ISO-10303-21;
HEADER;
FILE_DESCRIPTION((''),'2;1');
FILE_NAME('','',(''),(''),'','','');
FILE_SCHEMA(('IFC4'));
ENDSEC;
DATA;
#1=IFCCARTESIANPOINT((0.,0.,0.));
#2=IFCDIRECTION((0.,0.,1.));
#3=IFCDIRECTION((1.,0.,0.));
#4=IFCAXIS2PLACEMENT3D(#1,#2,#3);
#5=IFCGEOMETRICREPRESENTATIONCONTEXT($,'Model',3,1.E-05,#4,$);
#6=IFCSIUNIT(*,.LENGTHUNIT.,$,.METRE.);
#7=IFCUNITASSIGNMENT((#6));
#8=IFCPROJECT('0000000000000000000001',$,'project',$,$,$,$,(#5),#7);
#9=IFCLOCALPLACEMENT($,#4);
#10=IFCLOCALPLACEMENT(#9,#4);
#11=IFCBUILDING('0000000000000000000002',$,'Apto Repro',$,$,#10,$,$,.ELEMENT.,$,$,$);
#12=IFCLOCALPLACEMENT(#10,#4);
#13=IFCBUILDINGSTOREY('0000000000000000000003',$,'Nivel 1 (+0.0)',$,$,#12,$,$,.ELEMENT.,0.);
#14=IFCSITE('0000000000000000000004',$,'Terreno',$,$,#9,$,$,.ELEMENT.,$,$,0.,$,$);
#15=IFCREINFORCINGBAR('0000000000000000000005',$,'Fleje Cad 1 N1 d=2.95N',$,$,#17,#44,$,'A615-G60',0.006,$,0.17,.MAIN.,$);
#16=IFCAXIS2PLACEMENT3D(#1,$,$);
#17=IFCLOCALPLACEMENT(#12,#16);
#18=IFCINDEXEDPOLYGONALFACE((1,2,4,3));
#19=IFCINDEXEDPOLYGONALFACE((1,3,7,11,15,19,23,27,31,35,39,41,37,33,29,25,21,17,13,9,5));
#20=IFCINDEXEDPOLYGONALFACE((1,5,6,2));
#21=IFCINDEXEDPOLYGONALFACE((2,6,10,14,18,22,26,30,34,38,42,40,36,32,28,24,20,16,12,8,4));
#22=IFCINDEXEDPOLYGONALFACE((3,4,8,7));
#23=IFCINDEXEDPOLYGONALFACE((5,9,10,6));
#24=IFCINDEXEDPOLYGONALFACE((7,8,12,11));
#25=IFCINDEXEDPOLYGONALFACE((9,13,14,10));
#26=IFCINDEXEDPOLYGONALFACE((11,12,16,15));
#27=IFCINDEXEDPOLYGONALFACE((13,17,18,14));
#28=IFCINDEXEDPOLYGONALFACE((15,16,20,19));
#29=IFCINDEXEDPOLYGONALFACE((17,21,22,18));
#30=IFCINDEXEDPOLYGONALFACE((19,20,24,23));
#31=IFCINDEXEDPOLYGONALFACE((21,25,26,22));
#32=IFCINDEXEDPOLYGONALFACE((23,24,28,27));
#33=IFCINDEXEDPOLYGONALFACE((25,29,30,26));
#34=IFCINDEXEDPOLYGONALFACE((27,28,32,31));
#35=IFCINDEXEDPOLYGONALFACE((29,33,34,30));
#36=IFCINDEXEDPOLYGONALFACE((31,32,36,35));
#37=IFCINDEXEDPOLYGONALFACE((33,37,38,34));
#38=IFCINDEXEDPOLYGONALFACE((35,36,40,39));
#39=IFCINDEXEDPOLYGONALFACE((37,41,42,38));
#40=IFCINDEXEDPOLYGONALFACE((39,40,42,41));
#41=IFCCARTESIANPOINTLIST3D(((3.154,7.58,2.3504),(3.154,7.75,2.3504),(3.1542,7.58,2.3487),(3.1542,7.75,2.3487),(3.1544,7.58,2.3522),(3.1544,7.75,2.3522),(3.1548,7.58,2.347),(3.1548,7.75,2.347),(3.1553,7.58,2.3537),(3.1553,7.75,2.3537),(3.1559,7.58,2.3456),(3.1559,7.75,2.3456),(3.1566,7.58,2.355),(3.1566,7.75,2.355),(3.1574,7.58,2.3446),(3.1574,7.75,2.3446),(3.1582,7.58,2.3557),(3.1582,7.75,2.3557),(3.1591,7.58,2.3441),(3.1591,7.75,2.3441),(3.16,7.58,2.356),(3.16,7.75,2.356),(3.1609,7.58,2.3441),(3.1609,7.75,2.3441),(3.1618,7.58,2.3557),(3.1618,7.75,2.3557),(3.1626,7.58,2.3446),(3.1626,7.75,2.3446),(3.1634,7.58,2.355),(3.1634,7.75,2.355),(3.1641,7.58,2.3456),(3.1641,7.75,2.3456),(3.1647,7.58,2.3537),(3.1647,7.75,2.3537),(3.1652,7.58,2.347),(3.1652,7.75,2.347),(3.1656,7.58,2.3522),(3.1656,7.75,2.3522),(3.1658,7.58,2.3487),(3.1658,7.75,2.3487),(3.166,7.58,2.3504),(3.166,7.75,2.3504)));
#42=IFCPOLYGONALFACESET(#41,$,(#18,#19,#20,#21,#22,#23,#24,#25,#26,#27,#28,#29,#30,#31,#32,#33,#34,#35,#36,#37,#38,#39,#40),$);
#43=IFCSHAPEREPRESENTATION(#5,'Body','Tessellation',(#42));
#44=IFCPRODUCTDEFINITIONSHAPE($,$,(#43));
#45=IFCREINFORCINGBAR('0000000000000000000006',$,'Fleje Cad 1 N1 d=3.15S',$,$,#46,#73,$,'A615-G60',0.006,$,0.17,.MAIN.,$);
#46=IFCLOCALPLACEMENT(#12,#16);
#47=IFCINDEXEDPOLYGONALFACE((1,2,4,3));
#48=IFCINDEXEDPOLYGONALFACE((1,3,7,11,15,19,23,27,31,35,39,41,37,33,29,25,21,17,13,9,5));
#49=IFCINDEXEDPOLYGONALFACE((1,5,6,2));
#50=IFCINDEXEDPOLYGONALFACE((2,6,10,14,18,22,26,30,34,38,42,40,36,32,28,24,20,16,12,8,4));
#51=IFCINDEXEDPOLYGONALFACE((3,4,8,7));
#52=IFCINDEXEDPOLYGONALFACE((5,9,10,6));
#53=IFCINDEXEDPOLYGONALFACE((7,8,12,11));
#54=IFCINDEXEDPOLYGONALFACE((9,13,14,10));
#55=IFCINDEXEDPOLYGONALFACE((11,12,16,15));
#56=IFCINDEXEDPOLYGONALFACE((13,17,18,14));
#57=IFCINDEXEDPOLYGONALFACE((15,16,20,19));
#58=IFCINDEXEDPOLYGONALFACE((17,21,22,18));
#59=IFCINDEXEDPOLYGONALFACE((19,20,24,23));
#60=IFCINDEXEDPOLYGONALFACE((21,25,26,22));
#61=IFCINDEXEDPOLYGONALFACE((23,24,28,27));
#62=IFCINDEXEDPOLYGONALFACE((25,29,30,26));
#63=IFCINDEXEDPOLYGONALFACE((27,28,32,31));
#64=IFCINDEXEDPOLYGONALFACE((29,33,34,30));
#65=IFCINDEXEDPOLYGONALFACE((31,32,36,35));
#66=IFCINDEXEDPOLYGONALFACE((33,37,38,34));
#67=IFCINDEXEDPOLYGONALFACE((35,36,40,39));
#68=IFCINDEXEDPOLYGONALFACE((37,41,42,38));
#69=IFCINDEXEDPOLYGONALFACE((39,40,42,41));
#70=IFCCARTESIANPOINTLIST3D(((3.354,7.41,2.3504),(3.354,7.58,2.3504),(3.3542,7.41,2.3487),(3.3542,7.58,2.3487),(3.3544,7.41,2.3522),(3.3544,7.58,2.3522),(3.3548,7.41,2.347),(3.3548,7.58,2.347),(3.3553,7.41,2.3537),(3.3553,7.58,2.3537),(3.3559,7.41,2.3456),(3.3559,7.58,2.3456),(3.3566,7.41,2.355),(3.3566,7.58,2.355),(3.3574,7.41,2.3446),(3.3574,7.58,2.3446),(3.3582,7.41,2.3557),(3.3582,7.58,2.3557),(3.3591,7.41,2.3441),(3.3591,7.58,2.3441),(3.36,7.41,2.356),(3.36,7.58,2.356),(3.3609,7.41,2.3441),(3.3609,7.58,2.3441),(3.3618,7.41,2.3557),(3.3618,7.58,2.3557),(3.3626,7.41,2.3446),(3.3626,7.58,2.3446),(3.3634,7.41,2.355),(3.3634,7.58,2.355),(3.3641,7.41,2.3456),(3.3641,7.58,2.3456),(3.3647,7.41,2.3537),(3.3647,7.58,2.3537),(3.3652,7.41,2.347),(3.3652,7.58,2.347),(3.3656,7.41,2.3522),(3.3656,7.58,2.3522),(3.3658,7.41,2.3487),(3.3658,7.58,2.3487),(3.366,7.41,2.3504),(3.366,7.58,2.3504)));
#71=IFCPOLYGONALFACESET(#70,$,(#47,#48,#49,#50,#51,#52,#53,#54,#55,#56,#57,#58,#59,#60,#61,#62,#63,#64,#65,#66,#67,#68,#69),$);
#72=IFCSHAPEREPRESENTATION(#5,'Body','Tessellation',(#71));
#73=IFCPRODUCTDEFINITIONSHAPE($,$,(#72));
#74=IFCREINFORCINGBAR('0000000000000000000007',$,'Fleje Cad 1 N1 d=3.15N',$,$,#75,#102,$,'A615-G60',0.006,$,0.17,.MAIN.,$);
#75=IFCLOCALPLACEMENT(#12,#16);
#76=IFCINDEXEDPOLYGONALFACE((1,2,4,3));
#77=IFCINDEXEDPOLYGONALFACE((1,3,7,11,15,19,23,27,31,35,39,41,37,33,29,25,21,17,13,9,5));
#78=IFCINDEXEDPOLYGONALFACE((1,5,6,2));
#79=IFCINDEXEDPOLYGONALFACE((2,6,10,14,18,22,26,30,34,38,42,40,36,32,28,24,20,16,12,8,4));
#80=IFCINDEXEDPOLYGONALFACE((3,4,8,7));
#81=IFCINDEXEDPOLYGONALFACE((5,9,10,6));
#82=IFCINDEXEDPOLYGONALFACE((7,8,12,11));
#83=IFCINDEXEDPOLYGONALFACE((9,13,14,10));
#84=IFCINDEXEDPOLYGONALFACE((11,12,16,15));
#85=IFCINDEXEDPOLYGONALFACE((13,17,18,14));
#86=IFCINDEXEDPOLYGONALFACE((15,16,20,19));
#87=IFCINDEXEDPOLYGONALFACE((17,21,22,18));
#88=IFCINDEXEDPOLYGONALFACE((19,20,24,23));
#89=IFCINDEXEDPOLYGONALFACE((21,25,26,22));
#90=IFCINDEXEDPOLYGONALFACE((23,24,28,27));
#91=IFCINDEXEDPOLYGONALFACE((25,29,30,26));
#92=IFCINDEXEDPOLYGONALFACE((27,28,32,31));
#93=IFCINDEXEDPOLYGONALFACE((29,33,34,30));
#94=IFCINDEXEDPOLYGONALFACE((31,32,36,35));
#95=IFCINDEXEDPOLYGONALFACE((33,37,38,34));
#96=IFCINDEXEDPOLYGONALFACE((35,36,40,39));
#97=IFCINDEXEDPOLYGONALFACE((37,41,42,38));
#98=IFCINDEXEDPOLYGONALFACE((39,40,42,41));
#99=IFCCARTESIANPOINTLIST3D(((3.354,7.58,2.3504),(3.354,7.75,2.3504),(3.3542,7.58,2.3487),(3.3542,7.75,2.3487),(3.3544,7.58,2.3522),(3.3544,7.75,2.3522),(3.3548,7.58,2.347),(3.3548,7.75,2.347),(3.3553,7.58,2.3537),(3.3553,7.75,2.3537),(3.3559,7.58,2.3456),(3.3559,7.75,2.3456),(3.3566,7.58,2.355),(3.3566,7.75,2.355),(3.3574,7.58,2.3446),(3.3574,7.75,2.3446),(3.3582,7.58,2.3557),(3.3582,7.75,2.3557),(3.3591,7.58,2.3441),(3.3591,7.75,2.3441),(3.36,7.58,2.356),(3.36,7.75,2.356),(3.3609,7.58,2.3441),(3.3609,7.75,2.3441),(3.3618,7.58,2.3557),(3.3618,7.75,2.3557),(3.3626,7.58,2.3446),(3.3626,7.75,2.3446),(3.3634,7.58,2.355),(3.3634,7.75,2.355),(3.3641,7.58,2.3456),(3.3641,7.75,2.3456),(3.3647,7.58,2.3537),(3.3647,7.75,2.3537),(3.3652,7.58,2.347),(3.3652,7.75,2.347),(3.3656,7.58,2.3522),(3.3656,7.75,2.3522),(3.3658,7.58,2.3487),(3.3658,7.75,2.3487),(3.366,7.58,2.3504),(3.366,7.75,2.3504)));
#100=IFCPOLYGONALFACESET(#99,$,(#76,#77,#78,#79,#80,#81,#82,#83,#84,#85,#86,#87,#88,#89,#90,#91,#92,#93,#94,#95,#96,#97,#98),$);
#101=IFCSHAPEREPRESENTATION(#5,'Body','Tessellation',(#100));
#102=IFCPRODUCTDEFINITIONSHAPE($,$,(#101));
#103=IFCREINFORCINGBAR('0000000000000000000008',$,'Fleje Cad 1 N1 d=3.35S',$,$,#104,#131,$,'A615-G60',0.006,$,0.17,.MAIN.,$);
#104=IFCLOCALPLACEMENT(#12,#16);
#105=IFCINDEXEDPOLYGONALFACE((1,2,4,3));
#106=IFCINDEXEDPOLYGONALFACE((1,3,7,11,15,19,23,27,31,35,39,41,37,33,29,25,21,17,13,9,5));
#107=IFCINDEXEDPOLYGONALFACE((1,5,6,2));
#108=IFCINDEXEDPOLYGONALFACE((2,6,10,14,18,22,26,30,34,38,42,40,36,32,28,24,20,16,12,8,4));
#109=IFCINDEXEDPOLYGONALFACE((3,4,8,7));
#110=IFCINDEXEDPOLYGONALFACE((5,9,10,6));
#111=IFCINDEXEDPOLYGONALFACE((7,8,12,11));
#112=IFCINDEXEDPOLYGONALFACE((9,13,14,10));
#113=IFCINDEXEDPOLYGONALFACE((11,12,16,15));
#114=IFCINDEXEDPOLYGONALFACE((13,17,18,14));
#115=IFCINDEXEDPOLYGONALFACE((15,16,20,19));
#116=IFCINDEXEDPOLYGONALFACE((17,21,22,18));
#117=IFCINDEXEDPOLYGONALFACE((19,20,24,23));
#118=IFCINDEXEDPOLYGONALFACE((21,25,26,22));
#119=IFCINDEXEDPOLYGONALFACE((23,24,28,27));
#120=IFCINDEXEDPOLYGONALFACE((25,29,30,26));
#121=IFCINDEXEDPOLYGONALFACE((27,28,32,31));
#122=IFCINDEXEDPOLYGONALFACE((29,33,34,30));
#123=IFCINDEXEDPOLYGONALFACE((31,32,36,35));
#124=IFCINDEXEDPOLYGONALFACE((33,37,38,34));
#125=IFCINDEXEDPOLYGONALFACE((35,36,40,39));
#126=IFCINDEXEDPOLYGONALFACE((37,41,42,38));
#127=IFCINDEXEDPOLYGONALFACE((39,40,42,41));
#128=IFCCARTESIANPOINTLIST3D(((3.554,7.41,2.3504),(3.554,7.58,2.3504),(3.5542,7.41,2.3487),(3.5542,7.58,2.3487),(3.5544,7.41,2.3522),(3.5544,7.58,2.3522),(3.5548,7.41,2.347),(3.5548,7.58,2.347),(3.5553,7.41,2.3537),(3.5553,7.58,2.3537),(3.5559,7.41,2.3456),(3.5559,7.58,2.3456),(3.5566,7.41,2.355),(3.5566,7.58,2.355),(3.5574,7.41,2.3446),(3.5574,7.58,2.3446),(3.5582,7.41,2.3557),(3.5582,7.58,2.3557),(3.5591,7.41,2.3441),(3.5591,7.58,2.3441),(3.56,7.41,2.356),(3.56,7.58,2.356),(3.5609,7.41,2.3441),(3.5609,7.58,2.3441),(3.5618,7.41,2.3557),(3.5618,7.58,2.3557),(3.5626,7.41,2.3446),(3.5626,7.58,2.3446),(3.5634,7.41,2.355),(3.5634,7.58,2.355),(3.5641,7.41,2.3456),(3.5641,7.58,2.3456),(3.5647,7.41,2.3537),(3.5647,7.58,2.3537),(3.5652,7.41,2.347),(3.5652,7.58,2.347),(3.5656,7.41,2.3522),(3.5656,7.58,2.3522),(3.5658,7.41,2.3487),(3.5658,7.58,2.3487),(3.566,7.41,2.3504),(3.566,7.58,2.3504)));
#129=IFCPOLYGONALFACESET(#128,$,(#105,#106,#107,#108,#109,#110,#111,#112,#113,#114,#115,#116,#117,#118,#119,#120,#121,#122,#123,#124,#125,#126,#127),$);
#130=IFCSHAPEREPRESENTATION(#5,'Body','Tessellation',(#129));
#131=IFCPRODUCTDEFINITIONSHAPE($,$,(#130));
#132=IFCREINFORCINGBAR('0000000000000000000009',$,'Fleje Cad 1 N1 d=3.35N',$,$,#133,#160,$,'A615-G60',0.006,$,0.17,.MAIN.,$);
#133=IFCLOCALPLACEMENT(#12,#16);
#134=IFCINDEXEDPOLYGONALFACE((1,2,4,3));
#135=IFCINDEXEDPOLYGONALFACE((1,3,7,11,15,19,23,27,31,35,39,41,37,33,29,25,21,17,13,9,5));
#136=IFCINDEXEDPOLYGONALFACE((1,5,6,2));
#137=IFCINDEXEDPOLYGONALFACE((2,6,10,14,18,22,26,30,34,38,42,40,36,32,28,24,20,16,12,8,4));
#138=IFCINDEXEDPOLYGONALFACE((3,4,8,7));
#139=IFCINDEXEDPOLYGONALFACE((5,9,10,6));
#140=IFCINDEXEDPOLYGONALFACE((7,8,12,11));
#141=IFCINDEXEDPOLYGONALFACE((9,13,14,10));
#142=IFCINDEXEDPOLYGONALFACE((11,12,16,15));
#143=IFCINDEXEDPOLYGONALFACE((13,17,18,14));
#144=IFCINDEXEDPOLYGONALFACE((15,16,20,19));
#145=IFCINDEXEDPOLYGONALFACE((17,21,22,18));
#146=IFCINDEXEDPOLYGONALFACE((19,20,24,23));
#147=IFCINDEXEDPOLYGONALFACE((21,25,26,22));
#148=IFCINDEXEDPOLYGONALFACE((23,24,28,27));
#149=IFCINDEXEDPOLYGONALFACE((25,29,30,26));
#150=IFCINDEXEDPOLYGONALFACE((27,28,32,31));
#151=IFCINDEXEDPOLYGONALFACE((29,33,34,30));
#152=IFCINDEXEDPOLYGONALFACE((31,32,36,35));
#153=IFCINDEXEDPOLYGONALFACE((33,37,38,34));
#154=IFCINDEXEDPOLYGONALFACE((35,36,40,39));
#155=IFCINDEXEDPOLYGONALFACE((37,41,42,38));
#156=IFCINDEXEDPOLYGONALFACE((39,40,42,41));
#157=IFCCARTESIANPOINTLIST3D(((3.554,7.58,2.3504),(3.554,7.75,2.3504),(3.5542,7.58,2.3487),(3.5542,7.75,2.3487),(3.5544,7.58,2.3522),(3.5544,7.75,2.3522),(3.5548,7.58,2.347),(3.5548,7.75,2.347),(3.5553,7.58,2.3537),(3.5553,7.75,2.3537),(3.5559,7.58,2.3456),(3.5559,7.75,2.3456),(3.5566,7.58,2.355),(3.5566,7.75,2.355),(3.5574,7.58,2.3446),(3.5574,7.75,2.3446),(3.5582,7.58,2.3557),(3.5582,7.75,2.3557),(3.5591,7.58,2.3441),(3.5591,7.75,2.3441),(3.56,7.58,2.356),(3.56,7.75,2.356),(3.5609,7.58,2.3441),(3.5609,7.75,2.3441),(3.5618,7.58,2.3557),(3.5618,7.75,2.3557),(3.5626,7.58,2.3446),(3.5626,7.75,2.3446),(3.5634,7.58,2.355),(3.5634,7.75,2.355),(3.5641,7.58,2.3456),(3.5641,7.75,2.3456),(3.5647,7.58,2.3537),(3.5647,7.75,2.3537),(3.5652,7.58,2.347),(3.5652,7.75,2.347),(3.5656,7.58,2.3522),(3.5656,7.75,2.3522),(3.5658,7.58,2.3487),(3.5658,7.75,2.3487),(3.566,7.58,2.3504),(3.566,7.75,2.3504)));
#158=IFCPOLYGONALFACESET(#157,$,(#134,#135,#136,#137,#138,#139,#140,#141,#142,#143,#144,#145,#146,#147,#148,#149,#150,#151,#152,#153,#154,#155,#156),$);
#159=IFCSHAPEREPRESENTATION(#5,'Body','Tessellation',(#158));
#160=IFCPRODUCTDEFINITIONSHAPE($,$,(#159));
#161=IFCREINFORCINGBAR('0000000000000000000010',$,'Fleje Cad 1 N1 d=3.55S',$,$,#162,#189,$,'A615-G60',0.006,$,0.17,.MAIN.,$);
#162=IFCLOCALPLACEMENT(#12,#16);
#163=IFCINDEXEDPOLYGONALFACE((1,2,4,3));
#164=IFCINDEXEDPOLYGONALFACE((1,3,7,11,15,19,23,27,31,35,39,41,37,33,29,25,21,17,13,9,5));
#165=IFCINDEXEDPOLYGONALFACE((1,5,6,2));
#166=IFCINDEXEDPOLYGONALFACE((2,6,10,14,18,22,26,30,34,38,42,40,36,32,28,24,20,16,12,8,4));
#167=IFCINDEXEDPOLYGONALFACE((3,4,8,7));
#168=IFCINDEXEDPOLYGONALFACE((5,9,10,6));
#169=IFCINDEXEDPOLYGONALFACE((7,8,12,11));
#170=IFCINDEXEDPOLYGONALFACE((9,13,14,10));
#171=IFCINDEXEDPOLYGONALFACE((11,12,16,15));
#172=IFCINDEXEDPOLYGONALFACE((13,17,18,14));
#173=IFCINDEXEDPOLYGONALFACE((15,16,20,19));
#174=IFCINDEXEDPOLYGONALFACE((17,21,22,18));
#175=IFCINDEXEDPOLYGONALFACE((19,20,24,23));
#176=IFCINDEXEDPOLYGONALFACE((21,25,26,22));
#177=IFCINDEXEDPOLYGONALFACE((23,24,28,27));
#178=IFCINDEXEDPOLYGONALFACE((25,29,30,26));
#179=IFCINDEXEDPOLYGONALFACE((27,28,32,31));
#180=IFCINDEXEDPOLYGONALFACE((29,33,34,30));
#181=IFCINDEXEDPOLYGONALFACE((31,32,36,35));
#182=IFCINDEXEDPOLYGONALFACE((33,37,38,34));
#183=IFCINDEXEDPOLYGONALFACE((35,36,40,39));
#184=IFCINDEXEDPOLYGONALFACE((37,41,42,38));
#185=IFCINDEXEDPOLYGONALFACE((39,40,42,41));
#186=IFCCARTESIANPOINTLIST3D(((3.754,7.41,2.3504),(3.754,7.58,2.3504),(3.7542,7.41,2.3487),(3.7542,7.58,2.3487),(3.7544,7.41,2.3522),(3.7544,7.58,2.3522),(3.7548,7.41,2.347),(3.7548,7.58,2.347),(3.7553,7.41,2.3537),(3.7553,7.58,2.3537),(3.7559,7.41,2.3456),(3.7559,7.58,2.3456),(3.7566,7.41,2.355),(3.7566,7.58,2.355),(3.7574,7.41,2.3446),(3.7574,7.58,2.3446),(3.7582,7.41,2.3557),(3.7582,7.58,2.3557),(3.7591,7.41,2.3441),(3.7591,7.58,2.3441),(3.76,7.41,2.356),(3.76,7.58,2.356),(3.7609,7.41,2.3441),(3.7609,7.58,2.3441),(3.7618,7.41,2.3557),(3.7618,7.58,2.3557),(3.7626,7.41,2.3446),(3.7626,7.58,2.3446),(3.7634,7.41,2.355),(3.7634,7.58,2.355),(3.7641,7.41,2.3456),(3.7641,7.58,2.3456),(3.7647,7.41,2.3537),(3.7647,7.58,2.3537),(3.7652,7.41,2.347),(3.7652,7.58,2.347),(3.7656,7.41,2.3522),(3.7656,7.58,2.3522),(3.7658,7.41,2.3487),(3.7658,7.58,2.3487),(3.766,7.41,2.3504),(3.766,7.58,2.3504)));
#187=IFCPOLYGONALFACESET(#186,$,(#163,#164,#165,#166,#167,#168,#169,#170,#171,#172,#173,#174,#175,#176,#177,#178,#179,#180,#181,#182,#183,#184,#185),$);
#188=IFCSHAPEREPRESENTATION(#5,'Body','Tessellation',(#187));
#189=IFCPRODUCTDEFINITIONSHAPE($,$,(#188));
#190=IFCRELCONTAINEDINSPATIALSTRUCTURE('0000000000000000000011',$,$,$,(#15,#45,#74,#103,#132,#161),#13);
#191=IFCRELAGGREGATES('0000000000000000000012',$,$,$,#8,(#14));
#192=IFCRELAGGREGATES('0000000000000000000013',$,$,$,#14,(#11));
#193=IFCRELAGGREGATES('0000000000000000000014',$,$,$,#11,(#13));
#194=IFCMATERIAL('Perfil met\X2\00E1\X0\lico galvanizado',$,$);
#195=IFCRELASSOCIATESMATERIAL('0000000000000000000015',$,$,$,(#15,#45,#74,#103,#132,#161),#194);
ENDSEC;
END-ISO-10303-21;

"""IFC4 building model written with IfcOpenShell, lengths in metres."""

from ifc_helpers import new_model, si_unit, frame, origin_with_axes, origin_2d_with_axis, place, context, project, spatial, circle, extrude, material, element, save


model = new_model("IFC4")

# Units and contexts
model_context = context("Model", 3, precision=1e-05, world=origin_with_axes())
ifc_project = project(units=[si_unit("LENGTHUNIT", "METRE")], contexts=[model_context])

# Site, building, storey
site_placement = place(None, origin_with_axes())
site = spatial("IfcSite", under=ifc_project, at=site_placement, Name="Terreno", CompositionType="ELEMENT", RefElevation=0.0)
building_placement = place(site_placement, origin_with_axes())
building = spatial("IfcBuilding", under=site, at=building_placement, Name="Apto Repro", CompositionType="ELEMENT")
storey_placement = place(building_placement, origin_with_axes())
storey = spatial("IfcBuildingStorey", under=building, at=storey_placement, Name="Nivel 1 (+0.0)", CompositionType="ELEMENT", Elevation=0.0)

# Reinforcing bars
ifc_material = material(Name="Perfil metálico galvanizado")
reinforcing_bar_1_placement = place(storey_placement, origin_with_axes())
element("IfcReinforcingBar", 1, at=reinforcing_bar_1_placement, inside=storey, material=ifc_material, Name="Fleje Cad 1 N1 d=2.95N", SteelGrade="A615-G60", BarLength=0.17, NominalDiameter=0.006, PredefinedType="MAIN", context=model_context, shape_type="SweptSolid", body=[
    extrude(circle(Radius=0.006, at=origin_2d_with_axis()), frame((3.16, 7.58, 2.35), z_axis=(0.0, 1.0, 0.0), x_axis=(0.0, 0.0, 1.0)), (0.0, 0.0, 1.0), 0.17),
])
reinforcing_bar_2_placement = place(storey_placement, origin_with_axes())
element("IfcReinforcingBar", 2, at=reinforcing_bar_2_placement, inside=storey, material=ifc_material, Name="Fleje Cad 1 N1 d=3.15S", SteelGrade="A615-G60", BarLength=0.17, NominalDiameter=0.006, PredefinedType="MAIN", context=model_context, shape_type="SweptSolid", body=[
    extrude(circle(Radius=0.006, at=origin_2d_with_axis()), frame((3.36, 7.41, 2.35), z_axis=(0.0, 1.0, 0.0), x_axis=(0.0, 0.0, 1.0)), (0.0, 0.0, 1.0), 0.17),
])
reinforcing_bar_3_placement = place(storey_placement, origin_with_axes())
element("IfcReinforcingBar", 3, at=reinforcing_bar_3_placement, inside=storey, material=ifc_material, Name="Fleje Cad 1 N1 d=3.15N", SteelGrade="A615-G60", BarLength=0.17, NominalDiameter=0.006, PredefinedType="MAIN", context=model_context, shape_type="SweptSolid", body=[
    extrude(circle(Radius=0.006, at=origin_2d_with_axis()), frame((3.36, 7.58, 2.35), z_axis=(0.0, 1.0, 0.0), x_axis=(0.0, 0.0, 1.0)), (0.0, 0.0, 1.0), 0.17),
])
reinforcing_bar_4_placement = place(storey_placement, origin_with_axes())
element("IfcReinforcingBar", 4, at=reinforcing_bar_4_placement, inside=storey, material=ifc_material, Name="Fleje Cad 1 N1 d=3.35S", SteelGrade="A615-G60", BarLength=0.17, NominalDiameter=0.006, PredefinedType="MAIN", context=model_context, shape_type="SweptSolid", body=[
    extrude(circle(Radius=0.006, at=origin_2d_with_axis()), frame((3.56, 7.41, 2.35), z_axis=(0.0, 1.0, 0.0), x_axis=(0.0, 0.0, 1.0)), (0.0, 0.0, 1.0), 0.17),
])
reinforcing_bar_5_placement = place(storey_placement, origin_with_axes())
element("IfcReinforcingBar", 5, at=reinforcing_bar_5_placement, inside=storey, material=ifc_material, Name="Fleje Cad 1 N1 d=3.35N", SteelGrade="A615-G60", BarLength=0.17, NominalDiameter=0.006, PredefinedType="MAIN", context=model_context, shape_type="SweptSolid", body=[
    extrude(circle(Radius=0.006, at=origin_2d_with_axis()), frame((3.56, 7.58, 2.35), z_axis=(0.0, 1.0, 0.0), x_axis=(0.0, 0.0, 1.0)), (0.0, 0.0, 1.0), 0.17),
])
reinforcing_bar_6_placement = place(storey_placement, origin_with_axes())
element("IfcReinforcingBar", 6, at=reinforcing_bar_6_placement, inside=storey, material=ifc_material, Name="Fleje Cad 1 N1 d=3.55S", SteelGrade="A615-G60", BarLength=0.17, NominalDiameter=0.006, PredefinedType="MAIN", context=model_context, shape_type="SweptSolid", body=[
    extrude(circle(Radius=0.006, at=origin_2d_with_axis()), frame((3.76, 7.41, 2.35), z_axis=(0.0, 1.0, 0.0), x_axis=(0.0, 0.0, 1.0)), (0.0, 0.0, 1.0), 0.17),
])

save(model, "model.ifc")
